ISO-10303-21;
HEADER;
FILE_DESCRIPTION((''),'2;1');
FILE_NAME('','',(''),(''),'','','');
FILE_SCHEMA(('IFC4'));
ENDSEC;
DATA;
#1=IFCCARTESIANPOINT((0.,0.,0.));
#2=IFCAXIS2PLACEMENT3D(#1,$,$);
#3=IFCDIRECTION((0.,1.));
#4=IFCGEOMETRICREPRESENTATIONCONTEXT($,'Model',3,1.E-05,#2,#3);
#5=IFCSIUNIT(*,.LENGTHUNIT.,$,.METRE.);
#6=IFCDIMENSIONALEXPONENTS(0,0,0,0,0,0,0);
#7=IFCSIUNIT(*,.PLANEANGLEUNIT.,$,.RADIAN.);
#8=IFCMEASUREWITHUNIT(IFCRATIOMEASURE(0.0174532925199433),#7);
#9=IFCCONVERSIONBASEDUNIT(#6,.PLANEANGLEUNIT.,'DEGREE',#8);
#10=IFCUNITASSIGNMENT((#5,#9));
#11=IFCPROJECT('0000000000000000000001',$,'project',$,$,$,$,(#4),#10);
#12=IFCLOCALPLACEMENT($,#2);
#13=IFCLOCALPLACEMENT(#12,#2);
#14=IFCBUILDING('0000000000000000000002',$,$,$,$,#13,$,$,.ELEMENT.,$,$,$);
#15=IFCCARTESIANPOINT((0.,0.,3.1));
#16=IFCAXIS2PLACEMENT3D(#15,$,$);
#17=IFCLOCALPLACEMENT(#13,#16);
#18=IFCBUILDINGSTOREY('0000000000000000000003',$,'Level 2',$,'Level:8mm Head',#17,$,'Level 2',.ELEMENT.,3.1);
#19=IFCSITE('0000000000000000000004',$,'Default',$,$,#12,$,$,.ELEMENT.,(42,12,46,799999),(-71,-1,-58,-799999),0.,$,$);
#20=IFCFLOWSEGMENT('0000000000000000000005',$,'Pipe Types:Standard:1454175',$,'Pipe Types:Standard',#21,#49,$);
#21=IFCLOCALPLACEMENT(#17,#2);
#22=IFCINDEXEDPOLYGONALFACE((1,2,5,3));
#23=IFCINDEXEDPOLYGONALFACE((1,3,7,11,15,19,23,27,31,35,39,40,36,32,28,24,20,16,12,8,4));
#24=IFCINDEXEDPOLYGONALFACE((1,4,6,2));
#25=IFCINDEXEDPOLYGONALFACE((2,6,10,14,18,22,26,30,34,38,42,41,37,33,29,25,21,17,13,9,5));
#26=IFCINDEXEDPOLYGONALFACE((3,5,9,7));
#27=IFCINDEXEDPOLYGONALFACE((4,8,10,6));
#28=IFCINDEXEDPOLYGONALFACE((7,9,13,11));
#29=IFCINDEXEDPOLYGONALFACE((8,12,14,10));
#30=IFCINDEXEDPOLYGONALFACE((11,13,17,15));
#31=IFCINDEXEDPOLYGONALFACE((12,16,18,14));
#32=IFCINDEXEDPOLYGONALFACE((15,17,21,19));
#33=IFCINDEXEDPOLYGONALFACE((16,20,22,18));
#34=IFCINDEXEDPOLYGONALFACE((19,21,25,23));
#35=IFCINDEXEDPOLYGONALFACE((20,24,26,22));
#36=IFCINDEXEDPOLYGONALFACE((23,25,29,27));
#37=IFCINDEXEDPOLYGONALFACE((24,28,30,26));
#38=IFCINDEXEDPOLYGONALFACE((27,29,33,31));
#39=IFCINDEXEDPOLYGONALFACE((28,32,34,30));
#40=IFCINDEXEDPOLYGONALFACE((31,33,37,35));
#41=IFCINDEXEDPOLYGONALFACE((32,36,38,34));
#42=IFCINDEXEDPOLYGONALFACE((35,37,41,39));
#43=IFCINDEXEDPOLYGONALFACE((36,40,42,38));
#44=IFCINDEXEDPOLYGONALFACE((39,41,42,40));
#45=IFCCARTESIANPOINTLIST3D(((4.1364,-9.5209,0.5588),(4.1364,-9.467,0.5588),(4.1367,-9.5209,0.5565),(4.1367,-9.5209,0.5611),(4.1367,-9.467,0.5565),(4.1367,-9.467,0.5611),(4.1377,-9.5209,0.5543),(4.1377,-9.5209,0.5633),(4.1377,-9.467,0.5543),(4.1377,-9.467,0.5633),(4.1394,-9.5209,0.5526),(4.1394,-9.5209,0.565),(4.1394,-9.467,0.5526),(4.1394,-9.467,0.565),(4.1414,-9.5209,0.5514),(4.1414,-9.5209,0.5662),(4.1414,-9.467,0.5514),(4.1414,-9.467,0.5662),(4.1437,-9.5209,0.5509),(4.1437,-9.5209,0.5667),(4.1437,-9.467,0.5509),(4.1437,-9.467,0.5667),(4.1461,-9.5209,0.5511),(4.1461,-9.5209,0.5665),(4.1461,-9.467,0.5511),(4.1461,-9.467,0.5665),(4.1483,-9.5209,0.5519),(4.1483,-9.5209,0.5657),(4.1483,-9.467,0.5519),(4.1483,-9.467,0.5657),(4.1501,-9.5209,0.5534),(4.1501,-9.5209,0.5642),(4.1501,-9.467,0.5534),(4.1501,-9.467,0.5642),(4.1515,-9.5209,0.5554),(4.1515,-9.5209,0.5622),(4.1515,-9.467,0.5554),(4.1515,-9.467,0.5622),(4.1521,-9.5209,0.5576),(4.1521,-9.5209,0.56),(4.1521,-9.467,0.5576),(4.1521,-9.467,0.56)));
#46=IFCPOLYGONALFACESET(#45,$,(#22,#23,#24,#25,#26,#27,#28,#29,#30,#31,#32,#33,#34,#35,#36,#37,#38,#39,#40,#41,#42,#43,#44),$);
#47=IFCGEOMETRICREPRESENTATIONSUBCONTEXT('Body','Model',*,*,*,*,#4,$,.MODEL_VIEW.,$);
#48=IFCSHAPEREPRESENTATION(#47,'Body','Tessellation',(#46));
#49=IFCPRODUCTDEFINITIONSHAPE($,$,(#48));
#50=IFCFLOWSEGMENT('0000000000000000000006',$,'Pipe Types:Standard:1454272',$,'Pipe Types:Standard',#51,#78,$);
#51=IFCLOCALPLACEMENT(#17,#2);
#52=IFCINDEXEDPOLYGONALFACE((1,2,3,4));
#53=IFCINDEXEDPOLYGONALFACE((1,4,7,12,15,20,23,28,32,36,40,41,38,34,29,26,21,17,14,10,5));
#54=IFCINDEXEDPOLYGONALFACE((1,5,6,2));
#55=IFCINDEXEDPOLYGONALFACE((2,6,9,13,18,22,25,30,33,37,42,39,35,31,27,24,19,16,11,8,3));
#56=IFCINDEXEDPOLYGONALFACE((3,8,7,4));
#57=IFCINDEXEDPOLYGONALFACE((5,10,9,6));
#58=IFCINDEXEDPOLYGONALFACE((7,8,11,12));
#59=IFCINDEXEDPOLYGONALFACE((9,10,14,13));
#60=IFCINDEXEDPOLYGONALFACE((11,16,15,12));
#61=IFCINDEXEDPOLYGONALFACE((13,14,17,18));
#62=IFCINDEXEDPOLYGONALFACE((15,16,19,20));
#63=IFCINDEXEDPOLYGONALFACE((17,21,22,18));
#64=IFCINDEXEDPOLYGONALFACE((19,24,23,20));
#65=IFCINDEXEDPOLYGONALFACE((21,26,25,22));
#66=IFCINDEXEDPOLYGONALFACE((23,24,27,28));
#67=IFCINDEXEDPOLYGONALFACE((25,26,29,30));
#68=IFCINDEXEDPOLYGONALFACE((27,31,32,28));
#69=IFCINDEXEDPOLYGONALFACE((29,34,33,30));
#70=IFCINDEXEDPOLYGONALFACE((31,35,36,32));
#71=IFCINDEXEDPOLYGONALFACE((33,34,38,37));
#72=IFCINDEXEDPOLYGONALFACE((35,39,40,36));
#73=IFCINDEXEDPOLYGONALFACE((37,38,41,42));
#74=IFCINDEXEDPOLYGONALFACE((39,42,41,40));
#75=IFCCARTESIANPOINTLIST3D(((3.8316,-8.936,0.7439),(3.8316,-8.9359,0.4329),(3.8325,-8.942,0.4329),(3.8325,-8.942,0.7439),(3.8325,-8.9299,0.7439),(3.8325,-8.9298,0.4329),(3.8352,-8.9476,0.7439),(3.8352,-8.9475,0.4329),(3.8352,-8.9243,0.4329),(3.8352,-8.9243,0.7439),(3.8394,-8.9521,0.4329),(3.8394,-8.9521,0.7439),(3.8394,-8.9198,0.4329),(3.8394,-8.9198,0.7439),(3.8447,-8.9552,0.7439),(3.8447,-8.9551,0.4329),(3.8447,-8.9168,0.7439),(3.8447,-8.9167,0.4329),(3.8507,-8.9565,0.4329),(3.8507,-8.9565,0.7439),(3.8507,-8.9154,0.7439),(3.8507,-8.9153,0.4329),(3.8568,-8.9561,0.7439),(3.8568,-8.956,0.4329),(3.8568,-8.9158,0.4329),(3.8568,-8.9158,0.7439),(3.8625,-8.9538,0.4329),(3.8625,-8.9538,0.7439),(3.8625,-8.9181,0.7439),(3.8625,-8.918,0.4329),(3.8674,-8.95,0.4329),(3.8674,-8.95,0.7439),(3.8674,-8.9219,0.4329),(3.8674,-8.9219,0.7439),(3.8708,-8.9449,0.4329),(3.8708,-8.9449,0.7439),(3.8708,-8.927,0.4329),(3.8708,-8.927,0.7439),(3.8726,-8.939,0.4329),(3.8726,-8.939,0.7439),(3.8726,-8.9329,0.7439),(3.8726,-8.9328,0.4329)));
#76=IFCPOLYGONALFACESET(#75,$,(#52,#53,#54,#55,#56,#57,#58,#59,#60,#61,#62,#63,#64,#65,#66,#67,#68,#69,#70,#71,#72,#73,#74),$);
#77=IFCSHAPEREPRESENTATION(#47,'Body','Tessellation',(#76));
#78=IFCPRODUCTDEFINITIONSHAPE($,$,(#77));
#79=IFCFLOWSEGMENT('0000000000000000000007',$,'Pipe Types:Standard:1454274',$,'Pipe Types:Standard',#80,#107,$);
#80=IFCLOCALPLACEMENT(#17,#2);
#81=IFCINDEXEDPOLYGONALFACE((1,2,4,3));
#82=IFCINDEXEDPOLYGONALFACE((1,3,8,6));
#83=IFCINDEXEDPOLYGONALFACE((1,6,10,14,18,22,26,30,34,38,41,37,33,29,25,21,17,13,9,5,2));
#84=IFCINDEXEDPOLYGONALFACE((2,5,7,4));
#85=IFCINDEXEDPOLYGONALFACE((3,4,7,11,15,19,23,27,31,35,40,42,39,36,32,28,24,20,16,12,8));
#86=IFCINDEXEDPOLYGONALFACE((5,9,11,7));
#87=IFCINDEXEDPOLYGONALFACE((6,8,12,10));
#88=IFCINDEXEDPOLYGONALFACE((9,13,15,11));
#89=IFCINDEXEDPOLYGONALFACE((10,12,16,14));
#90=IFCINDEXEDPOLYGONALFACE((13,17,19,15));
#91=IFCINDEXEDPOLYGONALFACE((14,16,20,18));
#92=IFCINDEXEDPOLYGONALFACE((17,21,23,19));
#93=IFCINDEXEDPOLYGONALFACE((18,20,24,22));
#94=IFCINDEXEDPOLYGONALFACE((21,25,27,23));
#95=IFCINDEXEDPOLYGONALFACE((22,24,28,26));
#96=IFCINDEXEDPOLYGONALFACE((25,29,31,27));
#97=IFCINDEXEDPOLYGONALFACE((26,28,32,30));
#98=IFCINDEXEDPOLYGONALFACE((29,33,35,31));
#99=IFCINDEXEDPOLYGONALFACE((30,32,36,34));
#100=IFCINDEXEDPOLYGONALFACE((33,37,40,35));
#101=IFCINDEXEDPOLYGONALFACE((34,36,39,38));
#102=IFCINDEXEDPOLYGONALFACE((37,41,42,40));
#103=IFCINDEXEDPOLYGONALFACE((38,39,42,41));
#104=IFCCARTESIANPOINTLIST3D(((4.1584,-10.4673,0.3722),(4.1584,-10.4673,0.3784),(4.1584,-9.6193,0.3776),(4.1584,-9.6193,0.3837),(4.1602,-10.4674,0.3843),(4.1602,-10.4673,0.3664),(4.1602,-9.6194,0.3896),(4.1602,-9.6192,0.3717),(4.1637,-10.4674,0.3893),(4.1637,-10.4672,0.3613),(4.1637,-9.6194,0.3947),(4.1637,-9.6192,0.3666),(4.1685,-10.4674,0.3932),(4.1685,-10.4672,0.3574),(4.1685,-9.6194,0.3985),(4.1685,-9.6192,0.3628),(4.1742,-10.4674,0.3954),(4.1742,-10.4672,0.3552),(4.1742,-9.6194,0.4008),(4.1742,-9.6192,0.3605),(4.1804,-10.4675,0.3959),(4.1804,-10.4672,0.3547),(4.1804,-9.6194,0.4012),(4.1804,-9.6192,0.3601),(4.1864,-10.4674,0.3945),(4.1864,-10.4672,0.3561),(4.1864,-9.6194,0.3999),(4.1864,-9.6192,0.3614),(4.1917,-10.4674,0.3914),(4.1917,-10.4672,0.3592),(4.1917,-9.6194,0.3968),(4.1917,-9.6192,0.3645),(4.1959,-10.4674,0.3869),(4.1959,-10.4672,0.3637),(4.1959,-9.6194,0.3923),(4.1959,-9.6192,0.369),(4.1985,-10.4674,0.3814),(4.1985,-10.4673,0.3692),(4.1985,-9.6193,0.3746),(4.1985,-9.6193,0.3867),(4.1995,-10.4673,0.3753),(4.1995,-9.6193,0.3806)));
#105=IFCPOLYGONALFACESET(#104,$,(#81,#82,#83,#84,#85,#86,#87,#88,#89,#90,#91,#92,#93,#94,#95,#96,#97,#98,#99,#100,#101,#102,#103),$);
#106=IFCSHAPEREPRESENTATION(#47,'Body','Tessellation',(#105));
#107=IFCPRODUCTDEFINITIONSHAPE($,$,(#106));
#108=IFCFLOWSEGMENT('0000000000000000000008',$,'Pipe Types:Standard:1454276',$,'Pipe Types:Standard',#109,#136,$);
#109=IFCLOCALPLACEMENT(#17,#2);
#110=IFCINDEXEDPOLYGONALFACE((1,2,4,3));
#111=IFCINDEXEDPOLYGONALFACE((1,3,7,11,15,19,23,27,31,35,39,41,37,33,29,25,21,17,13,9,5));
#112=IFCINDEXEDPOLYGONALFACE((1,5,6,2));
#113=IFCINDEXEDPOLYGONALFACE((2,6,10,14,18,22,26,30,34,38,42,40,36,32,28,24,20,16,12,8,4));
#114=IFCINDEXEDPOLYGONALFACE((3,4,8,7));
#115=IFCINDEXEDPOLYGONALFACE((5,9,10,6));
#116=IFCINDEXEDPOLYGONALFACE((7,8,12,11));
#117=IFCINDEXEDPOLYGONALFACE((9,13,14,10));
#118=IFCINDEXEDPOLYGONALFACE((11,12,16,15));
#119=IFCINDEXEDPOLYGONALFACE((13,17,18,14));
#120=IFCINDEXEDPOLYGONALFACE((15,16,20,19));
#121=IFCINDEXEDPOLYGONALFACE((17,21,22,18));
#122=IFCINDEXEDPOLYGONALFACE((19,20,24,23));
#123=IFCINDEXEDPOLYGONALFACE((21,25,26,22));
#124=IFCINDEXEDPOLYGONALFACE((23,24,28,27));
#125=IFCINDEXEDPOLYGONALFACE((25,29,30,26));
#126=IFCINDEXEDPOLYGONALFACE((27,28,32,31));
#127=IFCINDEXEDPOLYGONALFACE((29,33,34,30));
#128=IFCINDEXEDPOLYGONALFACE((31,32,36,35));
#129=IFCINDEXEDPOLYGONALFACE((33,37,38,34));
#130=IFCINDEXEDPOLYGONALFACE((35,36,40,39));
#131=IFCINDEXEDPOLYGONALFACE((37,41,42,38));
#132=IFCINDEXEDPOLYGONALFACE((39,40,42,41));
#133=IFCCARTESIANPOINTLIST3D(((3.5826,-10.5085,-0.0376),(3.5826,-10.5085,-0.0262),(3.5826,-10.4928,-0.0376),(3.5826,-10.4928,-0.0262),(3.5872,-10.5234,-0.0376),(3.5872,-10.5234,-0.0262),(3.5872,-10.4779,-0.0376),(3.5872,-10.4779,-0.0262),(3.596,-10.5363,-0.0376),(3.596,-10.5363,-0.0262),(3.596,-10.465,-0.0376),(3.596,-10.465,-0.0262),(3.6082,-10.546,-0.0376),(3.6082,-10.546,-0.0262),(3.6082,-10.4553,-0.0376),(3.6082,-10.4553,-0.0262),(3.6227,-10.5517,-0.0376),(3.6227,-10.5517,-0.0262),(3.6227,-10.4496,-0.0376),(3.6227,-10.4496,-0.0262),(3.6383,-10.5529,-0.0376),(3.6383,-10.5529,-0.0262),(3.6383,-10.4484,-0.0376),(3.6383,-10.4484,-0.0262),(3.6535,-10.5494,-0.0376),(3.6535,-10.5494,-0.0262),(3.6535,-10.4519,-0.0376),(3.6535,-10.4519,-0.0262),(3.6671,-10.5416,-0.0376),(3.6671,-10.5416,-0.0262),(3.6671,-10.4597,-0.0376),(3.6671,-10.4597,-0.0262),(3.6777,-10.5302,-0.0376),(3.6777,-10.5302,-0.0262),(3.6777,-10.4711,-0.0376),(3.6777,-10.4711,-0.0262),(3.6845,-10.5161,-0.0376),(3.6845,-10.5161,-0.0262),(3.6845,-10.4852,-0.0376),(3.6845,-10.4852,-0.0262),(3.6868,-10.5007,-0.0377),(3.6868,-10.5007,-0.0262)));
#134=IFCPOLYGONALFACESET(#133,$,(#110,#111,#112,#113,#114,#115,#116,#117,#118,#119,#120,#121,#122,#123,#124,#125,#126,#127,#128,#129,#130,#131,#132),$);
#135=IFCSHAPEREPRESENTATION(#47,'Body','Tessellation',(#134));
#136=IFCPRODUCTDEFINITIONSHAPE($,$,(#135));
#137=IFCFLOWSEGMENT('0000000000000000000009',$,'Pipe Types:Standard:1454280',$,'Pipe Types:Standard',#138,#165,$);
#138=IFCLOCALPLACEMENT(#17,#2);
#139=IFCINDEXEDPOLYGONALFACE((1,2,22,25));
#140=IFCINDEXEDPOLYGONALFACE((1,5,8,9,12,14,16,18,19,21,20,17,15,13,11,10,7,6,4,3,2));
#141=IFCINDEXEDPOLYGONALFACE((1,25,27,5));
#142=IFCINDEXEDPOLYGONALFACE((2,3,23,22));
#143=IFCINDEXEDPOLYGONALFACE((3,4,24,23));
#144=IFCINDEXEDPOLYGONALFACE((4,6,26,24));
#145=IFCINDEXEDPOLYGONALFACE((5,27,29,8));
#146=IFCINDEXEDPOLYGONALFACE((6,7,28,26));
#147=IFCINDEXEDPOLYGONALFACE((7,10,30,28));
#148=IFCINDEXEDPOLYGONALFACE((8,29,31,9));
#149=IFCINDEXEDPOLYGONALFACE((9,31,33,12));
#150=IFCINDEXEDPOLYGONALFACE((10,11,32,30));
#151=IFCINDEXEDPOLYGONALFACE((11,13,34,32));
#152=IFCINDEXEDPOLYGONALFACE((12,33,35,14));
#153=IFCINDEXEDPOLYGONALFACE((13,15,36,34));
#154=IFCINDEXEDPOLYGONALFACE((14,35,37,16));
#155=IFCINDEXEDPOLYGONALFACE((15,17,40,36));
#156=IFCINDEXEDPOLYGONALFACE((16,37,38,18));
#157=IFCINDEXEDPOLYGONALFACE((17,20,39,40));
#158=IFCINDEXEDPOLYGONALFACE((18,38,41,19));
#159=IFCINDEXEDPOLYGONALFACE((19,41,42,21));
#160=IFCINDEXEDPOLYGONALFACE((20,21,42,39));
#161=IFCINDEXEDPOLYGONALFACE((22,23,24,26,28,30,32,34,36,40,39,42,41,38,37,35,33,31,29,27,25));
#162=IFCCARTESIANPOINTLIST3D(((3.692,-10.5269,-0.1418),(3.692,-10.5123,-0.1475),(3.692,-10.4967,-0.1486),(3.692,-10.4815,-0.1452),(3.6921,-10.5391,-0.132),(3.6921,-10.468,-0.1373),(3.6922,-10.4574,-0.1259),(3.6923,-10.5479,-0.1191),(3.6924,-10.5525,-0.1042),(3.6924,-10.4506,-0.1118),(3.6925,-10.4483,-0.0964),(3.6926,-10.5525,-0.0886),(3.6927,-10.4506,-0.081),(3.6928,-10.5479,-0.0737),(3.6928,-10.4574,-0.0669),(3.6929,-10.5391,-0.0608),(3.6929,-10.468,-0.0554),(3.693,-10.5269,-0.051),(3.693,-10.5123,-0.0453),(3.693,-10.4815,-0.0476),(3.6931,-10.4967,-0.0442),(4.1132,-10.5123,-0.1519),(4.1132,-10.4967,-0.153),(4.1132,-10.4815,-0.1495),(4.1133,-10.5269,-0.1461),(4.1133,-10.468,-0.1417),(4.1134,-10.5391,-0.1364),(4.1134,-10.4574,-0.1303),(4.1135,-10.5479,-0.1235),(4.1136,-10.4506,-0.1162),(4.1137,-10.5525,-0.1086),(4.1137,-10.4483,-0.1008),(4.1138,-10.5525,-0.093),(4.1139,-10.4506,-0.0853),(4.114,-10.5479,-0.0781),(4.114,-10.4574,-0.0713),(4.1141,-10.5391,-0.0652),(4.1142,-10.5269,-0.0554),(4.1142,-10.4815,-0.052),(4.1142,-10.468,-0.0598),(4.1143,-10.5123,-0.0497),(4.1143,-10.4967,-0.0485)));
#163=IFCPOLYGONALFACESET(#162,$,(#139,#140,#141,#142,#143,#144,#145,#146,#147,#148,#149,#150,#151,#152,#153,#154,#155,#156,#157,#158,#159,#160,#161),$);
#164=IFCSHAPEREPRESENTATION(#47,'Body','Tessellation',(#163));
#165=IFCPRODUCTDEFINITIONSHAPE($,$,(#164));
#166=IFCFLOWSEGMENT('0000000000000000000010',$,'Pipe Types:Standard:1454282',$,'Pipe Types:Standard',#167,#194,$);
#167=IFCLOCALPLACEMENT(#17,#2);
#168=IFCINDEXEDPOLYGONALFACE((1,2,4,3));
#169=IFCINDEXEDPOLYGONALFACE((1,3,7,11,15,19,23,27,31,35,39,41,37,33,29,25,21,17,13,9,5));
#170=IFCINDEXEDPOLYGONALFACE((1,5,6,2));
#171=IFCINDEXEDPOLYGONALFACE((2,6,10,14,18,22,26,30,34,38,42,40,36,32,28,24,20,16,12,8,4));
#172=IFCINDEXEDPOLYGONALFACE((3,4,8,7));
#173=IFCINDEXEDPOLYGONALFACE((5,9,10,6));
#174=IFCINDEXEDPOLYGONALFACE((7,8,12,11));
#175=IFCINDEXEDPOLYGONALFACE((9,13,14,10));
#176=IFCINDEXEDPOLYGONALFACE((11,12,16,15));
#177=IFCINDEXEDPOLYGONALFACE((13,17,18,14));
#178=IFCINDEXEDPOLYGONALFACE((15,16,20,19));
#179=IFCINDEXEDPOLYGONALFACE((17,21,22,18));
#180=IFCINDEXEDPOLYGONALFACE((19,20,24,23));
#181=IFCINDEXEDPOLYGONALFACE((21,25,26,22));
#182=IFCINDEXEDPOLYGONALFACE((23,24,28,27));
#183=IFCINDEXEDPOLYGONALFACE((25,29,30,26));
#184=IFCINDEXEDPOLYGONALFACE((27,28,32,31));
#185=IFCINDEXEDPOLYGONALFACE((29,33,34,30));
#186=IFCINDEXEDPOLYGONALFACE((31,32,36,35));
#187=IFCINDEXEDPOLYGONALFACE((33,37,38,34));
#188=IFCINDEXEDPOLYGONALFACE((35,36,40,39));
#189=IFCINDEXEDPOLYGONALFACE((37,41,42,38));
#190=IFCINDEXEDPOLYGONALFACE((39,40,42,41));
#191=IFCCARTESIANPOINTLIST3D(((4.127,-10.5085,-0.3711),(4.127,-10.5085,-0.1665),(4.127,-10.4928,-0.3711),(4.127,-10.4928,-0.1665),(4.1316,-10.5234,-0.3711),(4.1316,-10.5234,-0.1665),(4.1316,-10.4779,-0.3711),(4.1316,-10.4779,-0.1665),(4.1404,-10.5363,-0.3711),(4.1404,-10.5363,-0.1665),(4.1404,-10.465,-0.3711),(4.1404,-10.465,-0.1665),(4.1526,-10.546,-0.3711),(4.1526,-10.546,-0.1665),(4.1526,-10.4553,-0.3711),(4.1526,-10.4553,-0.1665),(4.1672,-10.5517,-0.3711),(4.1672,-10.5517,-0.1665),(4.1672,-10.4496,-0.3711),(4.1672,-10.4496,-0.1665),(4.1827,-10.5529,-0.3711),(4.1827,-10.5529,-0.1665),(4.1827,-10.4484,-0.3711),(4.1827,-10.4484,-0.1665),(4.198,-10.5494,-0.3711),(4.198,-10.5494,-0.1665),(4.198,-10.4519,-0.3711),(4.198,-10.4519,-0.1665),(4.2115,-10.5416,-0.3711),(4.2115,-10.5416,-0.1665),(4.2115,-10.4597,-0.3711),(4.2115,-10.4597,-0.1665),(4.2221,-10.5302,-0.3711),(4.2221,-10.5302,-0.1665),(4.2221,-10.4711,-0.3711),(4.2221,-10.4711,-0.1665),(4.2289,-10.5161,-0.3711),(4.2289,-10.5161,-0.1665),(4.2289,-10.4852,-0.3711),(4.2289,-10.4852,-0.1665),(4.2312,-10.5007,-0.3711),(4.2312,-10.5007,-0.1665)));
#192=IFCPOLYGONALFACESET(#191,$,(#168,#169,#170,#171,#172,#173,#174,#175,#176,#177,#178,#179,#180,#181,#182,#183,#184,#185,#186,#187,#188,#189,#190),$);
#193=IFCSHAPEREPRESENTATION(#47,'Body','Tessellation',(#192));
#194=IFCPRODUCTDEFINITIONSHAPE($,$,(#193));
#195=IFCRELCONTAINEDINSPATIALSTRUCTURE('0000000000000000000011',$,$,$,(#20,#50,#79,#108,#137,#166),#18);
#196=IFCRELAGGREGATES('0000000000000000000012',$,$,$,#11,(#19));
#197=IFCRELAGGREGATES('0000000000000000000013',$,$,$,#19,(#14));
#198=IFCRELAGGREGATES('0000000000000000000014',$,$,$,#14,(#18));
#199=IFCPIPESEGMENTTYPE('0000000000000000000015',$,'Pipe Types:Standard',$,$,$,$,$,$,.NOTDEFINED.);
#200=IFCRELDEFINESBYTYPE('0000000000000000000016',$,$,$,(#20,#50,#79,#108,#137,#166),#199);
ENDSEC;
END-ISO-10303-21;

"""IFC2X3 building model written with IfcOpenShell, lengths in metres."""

from ifc_helpers import new_model, entity, si_unit, converted_unit, direction, frame, frame_2d, origin, origin_2d_with_axis, place, context, subcontext, project, spatial, circle, extrude, type_object, element, save


model = new_model("IFC2X3")

# Units and contexts
model_context = context("Model", 3, precision=1e-05, world=origin(), true_north=direction((0.0, 1.0)))
body_context = subcontext(model_context, "Body", "Model", "MODEL_VIEW")
ifc_project = project(units=[si_unit("LENGTHUNIT", "METRE"), converted_unit("PLANEANGLEUNIT", "DEGREE", entity("IfcRatioMeasure", 0.0174532925199433), si_unit("PLANEANGLEUNIT", "RADIAN"), dimensions=[0, 0, 0, 0, 0, 0, 0])], contexts=[model_context])

# Site, building, storey
site_placement = place(None, origin())
site = spatial("IfcSite", under=ifc_project, at=site_placement, Name="Default", CompositionType="ELEMENT", RefLatitude=(42, 12, 46, 799999), RefLongitude=(-71, -1, -58, -799999), RefElevation=0.0)
building_placement = place(site_placement, origin())
building = spatial("IfcBuilding", under=site, at=building_placement, CompositionType="ELEMENT")
storey_placement = place(building_placement, frame((0.0, 0.0, 3.1)))
storey = spatial("IfcBuildingStorey", under=building, at=storey_placement, Name="Level 2", ObjectType="Level:8mm Head", LongName="Level 2", CompositionType="ELEMENT", Elevation=3.1)

# Flow segments
pipe_segment_type = type_object("IfcPipeSegmentType", Name="Pipe Types:Standard", PredefinedType="NOTDEFINED")
flow_segment_1_placement = place(storey_placement, origin())
element("IfcFlowSegment", 1, at=flow_segment_1_placement, inside=storey, type_object=pipe_segment_type, Name="Pipe Types:Standard:1454175", ObjectType="Pipe Types:Standard", context=body_context, shape_type="SweptSolid", body=[
    extrude(circle(Radius=0.0079, at=frame_2d((0.0, 0.0), x_axis=(1.0, 0.0))), frame((4.1443, -9.5209, 0.5588), z_axis=(0.0, 1.0, 0.0), x_axis=(-1.0, 0.0, 0.0)), (0.0, 0.0, 1.0), 0.0539),
])
flow_segment_2_placement = place(storey_placement, origin())
element("IfcFlowSegment", 2, at=flow_segment_2_placement, inside=storey, type_object=pipe_segment_type, Name="Pipe Types:Standard:1454272", ObjectType="Pipe Types:Standard", context=body_context, shape_type="SweptSolid", body=[
    extrude(circle(Radius=0.0206, at=origin_2d_with_axis()), frame((3.8522, -8.9359, 0.4329), z_axis=(0.0, -0.000149, 1.0), x_axis=(-1.0, 0.0, 0.0)), (0.0, 0.0, 1.0), 0.3109),
])
flow_segment_3_placement = place(storey_placement, origin())
element("IfcFlowSegment", 3, at=flow_segment_3_placement, inside=storey, type_object=pipe_segment_type, Name="Pipe Types:Standard:1454274", ObjectType="Pipe Types:Standard", context=body_context, shape_type="SweptSolid", body=[
    extrude(circle(Radius=0.0206, at=frame_2d((0.0, 0.0), x_axis=(1.0, 0.0))), frame((4.1788, -10.4673, 0.3753), z_axis=(0.0, 0.99998, 0.006302), x_axis=(1.0, 0.0, 0.0)), (0.0, 0.0, 1.0), 0.848),
])
flow_segment_4_placement = place(storey_placement, origin())
element("IfcFlowSegment", 4, at=flow_segment_4_placement, inside=storey, type_object=pipe_segment_type, Name="Pipe Types:Standard:1454276", ObjectType="Pipe Types:Standard", context=body_context, shape_type="SweptSolid", body=[
    extrude(circle(Radius=0.0524, at=origin_2d_with_axis()), frame((3.6344, -10.5007, -0.0376), z_axis=(0.00046, 0.0, 1.0), x_axis=(1.0, 0.0, -0.00046)), (0.0, 0.0, 1.0), 0.0114),
])
flow_segment_5_placement = place(storey_placement, origin())
element("IfcFlowSegment", 5, at=flow_segment_5_placement, inside=storey, type_object=pipe_segment_type, Name="Pipe Types:Standard:1454280", ObjectType="Pipe Types:Standard", context=body_context, shape_type="SweptSolid", body=[
    extrude(circle(Radius=0.0524, at=origin_2d_with_axis()), frame((3.6925, -10.5007, -0.0964), z_axis=(0.999946, 0.0, -0.010416), x_axis=(0.0, 1.0, 0.0)), (0.0, 0.0, 1.0), 0.4212),
])
flow_segment_6_placement = place(storey_placement, origin())
element("IfcFlowSegment", 6, at=flow_segment_6_placement, inside=storey, type_object=pipe_segment_type, Name="Pipe Types:Standard:1454282", ObjectType="Pipe Types:Standard", context=body_context, shape_type="SweptSolid", body=[
    extrude(circle(Radius=0.0524, at=frame_2d((0.0, 0.0), x_axis=(1.0, 0.0))), frame((4.1788, -10.5007, -0.3711)), (0.0, 0.0, 1.0), 0.2046),
])

save(model, "model.ifc")
